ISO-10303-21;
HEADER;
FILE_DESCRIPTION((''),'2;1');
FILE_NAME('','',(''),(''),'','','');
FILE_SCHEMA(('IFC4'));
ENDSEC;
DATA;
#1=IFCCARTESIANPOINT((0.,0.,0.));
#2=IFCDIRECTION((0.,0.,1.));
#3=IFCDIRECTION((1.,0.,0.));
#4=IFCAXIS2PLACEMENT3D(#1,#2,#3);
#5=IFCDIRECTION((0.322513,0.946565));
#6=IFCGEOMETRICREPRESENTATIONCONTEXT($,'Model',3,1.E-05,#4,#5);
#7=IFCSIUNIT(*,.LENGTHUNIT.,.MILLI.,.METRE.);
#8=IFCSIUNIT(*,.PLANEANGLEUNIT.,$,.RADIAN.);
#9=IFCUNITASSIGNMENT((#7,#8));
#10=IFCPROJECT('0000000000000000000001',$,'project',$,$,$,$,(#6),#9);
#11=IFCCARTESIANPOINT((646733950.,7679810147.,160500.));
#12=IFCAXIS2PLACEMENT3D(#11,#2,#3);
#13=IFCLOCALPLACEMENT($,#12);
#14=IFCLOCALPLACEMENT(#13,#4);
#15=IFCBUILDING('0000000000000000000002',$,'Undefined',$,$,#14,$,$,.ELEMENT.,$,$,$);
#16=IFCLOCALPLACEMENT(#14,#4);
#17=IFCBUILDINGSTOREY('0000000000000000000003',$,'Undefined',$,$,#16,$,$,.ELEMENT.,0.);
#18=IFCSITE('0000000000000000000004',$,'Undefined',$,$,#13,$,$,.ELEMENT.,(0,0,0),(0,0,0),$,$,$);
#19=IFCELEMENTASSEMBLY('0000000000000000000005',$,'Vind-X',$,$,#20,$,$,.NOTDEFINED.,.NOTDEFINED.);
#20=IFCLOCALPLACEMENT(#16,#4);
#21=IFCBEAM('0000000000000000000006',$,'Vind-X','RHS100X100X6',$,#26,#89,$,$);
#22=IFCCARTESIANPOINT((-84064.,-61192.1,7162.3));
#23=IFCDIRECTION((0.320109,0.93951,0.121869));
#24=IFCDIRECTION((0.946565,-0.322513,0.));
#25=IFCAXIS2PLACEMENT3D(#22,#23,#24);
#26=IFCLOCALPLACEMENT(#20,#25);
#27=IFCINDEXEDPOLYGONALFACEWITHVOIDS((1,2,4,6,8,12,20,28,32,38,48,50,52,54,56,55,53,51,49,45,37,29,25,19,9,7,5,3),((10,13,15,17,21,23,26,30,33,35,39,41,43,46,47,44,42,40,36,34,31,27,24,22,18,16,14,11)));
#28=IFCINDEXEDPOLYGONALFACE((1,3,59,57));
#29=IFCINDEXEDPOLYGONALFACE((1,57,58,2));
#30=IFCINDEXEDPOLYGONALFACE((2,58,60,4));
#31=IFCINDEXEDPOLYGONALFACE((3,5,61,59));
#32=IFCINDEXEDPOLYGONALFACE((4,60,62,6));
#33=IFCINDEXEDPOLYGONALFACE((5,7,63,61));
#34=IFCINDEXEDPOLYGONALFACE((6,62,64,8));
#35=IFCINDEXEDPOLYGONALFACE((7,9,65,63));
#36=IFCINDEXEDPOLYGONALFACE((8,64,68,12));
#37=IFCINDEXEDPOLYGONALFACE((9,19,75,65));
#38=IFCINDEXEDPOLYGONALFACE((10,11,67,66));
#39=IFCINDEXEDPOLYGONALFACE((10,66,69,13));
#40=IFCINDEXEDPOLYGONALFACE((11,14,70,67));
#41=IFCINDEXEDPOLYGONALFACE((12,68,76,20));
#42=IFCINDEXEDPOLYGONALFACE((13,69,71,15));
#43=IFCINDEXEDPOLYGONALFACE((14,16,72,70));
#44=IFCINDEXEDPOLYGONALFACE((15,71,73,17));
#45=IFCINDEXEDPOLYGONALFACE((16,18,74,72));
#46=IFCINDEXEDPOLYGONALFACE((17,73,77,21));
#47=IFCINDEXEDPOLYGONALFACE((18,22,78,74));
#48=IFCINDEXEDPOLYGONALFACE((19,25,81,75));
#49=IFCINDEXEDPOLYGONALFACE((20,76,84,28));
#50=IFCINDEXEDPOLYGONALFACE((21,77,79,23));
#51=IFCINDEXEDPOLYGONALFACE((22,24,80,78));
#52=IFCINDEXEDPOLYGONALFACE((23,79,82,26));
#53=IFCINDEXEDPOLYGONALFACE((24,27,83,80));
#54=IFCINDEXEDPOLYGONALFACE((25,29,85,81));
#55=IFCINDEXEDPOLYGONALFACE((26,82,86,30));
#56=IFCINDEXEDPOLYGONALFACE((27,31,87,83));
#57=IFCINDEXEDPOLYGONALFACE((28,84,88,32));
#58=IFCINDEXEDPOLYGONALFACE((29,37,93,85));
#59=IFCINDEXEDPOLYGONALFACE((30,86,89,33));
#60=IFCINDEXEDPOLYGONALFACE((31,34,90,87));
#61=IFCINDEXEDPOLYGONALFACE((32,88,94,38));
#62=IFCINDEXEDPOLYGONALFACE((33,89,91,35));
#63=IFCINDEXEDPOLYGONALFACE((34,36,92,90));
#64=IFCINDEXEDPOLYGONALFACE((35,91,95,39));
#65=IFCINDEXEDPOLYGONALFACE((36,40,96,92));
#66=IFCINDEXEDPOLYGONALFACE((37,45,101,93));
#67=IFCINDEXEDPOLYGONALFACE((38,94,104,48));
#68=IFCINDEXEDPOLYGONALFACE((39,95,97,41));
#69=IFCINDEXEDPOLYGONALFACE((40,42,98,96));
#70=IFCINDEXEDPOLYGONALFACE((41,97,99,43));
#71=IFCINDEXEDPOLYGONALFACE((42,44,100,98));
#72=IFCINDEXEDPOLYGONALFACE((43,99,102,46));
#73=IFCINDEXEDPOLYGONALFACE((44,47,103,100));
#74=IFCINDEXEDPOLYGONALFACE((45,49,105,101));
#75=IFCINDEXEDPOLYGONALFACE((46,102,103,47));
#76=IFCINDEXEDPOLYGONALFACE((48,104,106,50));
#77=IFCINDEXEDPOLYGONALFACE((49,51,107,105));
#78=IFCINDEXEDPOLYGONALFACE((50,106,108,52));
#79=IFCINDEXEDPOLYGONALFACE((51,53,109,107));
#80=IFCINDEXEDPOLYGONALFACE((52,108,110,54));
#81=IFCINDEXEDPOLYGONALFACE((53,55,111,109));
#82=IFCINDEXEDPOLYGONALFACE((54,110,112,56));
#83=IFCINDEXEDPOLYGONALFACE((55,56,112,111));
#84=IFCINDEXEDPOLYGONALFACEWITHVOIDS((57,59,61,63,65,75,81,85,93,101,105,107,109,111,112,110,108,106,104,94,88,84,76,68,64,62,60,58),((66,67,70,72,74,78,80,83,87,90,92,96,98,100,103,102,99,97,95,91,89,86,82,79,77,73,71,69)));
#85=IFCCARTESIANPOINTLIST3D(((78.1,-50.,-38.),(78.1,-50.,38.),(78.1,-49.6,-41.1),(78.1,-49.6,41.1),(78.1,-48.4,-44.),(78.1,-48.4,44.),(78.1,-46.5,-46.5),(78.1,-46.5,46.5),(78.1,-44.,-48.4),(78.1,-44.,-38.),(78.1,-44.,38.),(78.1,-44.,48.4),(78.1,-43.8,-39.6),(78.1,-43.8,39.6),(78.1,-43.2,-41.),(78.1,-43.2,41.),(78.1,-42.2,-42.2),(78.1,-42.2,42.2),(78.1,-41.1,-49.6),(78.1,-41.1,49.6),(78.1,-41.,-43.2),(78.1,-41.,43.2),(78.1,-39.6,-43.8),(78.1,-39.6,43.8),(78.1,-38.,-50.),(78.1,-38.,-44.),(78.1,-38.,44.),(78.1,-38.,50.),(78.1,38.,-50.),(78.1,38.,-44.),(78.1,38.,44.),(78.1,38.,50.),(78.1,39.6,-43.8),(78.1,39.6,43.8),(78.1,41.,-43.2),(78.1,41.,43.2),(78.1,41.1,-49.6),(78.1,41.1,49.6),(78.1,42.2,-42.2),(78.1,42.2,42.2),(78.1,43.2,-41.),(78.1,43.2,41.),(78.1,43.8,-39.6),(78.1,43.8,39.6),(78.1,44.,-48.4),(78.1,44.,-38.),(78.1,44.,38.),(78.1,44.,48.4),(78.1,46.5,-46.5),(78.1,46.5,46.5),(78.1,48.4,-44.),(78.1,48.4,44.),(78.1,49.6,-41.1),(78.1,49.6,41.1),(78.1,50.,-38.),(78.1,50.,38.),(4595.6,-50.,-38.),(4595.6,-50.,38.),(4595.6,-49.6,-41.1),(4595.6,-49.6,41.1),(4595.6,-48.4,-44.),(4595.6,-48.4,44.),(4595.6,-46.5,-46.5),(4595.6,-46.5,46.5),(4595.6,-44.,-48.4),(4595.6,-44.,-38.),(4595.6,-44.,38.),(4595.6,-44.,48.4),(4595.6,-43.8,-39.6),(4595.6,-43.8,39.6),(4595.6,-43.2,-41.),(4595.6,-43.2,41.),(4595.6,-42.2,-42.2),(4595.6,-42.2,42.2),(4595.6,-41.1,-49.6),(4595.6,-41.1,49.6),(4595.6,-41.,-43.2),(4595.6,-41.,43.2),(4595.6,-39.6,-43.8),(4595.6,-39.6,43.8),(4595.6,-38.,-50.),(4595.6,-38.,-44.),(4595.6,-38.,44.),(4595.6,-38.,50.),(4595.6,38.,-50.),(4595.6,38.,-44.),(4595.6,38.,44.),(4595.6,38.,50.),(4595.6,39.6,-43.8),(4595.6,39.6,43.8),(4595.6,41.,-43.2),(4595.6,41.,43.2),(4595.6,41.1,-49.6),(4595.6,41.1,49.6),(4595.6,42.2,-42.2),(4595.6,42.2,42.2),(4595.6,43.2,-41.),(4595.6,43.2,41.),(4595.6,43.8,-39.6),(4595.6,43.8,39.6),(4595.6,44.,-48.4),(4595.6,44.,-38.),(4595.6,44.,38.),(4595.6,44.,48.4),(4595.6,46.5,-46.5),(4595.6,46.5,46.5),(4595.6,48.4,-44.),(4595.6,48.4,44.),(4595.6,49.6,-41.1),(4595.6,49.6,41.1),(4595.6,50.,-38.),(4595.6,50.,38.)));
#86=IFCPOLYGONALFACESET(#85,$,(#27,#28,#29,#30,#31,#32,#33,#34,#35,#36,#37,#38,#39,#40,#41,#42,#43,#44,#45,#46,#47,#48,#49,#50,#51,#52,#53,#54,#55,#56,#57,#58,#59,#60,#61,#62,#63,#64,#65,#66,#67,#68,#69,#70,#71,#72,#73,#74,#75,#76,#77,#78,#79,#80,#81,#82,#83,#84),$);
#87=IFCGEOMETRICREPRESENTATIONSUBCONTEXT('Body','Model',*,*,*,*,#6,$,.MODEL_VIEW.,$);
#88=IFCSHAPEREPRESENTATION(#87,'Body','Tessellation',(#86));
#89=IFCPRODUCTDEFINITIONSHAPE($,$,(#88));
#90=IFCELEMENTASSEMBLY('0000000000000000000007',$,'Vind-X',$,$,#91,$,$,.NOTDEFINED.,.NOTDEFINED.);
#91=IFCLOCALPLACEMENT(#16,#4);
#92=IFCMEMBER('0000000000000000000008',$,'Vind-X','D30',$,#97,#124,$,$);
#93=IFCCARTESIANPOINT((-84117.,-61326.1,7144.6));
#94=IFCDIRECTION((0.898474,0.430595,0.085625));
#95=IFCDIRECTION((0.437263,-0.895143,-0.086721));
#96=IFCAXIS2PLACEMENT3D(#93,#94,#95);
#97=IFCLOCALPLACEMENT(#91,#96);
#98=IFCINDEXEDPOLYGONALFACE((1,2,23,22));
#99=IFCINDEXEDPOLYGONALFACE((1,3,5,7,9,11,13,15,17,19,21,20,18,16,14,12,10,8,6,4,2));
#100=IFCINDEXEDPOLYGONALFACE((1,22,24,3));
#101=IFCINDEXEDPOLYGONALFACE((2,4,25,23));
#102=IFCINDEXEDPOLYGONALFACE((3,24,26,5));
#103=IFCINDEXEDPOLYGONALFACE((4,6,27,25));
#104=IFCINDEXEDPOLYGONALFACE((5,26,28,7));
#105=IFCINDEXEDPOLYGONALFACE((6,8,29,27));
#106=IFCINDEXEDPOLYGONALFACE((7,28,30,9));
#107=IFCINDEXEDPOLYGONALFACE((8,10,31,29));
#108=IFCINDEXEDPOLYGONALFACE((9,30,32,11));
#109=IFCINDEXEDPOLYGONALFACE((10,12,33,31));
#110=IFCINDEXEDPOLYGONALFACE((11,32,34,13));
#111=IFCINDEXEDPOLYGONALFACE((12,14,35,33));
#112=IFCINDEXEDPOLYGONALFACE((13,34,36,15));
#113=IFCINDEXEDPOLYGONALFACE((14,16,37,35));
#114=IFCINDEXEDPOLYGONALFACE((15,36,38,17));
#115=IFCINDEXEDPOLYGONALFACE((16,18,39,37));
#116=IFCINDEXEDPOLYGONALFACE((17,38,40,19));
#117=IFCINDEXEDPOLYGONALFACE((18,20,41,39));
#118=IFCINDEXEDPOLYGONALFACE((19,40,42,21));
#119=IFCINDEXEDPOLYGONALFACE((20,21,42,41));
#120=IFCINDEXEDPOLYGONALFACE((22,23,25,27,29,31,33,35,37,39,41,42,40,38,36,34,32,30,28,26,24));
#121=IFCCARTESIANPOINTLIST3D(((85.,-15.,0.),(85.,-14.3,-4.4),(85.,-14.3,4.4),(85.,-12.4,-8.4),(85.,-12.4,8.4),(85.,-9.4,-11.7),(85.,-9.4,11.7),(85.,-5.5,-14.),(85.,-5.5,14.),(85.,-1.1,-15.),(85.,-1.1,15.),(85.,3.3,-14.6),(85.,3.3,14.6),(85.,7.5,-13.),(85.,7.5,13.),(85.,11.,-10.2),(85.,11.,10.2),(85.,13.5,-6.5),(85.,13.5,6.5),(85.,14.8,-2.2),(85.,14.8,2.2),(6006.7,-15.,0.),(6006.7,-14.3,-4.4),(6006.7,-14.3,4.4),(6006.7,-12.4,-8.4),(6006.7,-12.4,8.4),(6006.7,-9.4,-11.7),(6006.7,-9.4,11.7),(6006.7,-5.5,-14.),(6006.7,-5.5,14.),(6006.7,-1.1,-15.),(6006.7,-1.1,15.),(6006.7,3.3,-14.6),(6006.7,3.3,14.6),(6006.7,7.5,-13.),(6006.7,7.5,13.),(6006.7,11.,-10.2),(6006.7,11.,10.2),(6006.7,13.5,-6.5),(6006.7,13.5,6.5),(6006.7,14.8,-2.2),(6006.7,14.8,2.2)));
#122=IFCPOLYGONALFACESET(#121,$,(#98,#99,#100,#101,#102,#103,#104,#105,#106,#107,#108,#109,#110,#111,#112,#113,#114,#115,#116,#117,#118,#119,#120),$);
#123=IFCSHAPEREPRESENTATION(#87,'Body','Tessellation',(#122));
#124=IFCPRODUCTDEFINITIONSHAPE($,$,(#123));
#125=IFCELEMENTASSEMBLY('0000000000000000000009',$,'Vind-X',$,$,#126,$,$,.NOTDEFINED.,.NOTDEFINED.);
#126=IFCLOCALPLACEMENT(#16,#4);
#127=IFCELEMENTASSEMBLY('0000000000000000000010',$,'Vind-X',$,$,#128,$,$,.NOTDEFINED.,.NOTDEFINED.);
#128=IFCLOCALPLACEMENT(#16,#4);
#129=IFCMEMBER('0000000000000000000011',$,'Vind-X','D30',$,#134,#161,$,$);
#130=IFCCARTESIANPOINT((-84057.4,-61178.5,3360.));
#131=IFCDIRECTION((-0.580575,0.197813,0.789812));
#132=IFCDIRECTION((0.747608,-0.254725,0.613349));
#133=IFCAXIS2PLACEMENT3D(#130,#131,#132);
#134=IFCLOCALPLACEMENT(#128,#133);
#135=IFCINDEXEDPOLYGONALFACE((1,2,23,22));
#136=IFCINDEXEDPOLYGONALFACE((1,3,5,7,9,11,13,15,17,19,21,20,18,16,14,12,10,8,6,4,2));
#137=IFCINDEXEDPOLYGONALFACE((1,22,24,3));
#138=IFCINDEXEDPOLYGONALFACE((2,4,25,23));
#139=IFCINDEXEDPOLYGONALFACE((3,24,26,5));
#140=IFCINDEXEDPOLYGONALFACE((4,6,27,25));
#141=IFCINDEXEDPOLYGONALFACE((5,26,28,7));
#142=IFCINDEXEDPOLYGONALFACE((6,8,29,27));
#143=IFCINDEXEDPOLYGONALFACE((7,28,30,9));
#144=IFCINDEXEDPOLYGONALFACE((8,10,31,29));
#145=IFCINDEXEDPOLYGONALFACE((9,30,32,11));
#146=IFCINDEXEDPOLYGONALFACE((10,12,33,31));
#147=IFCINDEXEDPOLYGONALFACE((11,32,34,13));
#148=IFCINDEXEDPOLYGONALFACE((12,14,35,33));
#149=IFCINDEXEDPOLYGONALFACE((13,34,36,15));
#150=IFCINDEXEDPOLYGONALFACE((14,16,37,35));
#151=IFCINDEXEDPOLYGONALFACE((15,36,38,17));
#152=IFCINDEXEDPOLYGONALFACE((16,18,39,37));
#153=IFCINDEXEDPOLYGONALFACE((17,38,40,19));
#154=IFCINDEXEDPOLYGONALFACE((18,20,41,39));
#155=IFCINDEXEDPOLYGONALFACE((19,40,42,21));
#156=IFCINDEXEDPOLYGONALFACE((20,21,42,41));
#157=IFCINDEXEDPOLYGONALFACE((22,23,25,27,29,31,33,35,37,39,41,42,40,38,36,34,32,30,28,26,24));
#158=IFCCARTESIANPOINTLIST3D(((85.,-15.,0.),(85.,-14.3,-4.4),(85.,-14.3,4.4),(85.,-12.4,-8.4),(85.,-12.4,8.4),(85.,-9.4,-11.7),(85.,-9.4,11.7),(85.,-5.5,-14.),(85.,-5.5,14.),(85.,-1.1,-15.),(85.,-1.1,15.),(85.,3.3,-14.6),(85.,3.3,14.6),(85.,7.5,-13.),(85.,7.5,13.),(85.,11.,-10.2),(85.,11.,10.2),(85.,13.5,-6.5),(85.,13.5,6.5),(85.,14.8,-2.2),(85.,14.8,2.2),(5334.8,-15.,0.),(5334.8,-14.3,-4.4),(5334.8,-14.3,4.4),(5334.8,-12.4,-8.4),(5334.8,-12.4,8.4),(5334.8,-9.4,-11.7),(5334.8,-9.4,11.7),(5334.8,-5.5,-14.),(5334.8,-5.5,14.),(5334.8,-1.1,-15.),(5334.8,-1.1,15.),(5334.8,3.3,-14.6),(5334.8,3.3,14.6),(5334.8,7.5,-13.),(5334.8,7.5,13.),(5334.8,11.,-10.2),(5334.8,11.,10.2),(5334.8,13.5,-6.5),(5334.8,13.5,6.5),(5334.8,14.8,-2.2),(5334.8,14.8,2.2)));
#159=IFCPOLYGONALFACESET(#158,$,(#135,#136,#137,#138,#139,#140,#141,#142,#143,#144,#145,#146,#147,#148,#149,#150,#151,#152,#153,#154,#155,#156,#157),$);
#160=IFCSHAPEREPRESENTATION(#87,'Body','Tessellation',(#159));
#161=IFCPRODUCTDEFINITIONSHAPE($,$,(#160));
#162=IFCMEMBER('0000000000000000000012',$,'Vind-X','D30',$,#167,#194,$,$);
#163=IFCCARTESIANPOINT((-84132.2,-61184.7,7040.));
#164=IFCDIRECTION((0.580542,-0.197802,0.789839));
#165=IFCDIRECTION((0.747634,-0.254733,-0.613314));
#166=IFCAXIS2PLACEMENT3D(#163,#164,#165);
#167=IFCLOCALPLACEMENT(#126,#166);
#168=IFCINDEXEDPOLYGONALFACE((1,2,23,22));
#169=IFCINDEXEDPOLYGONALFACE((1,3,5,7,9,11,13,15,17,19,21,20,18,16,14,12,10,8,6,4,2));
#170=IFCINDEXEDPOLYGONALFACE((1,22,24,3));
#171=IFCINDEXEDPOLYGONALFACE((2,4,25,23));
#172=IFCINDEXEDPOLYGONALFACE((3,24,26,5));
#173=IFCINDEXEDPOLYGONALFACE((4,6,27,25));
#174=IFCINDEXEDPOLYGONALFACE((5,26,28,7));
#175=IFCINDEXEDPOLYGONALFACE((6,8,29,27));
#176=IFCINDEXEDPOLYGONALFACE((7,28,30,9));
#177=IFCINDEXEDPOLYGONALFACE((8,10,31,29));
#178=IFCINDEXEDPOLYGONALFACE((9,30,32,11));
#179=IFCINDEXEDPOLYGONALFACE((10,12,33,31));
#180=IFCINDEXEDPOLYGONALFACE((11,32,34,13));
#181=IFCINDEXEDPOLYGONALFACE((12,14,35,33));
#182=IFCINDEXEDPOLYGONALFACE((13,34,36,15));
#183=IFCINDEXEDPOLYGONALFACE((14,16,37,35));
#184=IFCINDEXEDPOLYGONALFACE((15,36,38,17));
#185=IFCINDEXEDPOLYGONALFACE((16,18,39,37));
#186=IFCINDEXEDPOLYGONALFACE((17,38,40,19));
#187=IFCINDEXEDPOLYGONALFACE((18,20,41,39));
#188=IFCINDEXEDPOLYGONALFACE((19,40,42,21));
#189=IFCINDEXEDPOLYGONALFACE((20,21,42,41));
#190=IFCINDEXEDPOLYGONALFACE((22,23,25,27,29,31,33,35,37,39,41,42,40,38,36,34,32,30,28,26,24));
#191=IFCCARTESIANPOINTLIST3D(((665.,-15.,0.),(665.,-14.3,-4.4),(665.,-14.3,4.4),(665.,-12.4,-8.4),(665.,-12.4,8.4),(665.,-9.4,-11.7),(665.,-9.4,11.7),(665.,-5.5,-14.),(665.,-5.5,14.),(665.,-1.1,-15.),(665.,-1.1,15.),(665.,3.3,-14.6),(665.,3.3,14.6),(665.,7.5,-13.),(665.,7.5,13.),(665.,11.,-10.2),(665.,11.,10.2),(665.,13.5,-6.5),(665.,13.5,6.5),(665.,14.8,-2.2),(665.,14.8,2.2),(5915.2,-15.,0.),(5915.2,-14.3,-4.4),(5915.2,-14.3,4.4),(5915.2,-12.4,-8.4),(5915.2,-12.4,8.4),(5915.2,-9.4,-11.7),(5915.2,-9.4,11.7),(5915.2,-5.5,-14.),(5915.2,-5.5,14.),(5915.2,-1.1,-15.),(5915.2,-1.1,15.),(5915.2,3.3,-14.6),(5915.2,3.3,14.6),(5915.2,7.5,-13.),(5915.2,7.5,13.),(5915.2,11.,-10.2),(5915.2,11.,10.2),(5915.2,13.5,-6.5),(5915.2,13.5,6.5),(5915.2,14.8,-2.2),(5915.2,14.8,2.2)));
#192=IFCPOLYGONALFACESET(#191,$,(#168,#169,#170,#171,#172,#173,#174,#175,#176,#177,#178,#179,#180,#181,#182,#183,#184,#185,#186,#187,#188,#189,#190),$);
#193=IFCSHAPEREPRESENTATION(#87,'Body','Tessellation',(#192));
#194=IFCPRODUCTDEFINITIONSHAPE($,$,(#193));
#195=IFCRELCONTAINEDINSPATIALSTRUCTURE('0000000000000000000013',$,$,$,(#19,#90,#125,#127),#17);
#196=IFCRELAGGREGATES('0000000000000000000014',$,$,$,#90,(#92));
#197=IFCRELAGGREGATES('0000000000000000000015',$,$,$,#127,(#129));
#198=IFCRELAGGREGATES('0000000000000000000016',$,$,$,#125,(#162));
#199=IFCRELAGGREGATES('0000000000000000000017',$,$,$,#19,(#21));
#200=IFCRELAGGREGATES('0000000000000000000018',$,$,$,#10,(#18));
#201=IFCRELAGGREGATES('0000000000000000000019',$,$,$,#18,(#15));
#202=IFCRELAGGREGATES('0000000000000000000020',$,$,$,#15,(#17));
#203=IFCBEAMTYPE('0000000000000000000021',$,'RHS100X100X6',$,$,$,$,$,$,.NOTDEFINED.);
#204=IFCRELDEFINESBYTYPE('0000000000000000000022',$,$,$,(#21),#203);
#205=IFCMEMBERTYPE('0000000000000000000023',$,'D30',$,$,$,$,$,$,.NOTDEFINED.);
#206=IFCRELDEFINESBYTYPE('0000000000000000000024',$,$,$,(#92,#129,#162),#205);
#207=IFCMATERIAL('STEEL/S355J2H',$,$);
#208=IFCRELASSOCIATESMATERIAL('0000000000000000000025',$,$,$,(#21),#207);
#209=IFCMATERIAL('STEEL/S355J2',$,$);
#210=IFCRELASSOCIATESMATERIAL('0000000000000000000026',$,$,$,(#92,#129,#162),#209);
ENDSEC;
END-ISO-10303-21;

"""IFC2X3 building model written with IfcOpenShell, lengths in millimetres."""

from ifc_helpers import new_model, si_unit, direction, frame, origin_with_axes, origin_2d_with_axis, place, context, subcontext, project, spatial, hollow_rectangle, circle, extrude, clip, halfspace, material, type_object, element, aggregate, save


model = new_model("IFC2X3")

# Units and contexts
model_context = context("Model", 3, precision=1e-05, world=origin_with_axes(), true_north=direction((0.322513, 0.946565)))
body_context = subcontext(model_context, "Body", "Model", "MODEL_VIEW")
ifc_project = project(units=[si_unit("LENGTHUNIT", "METRE", prefix="MILLI"), si_unit("PLANEANGLEUNIT", "RADIAN")], contexts=[model_context])

# Site, building, storey
site_placement = place(None, frame((646733950.0, 7679810147.0, 160500.0), z_axis=(0.0, 0.0, 1.0), x_axis=(1.0, 0.0, 0.0)))
site = spatial("IfcSite", under=ifc_project, at=site_placement, Name="Undefined", CompositionType="ELEMENT", RefLatitude=(0, 0, 0), RefLongitude=(0, 0, 0))
building_placement = place(site_placement, origin_with_axes())
building = spatial("IfcBuilding", under=site, at=building_placement, Name="Undefined", CompositionType="ELEMENT")
storey_placement = place(building_placement, origin_with_axes())
storey = spatial("IfcBuildingStorey", under=building, at=storey_placement, Name="Undefined", CompositionType="ELEMENT", Elevation=0.0)

# Shared definitions
ifc_material_1 = material(Name="STEEL/S355J2H")

# Element assembly, beam
assembly_1_placement = place(storey_placement, origin_with_axes())
assembly_1 = element("IfcElementAssembly", 1, at=assembly_1_placement, inside=storey, Name="Vind-X", AssemblyPlace="NOTDEFINED", PredefinedType="NOTDEFINED")
beam_type = type_object("IfcBeamType", Name="RHS100X100X6", PredefinedType="NOTDEFINED")
beam_placement = place(assembly_1_placement, frame((-84064.0, -61192.1, 7162.3), z_axis=(0.320109, 0.93951, 0.121869), x_axis=(0.946565, -0.322513, 0.0)))
beam = element("IfcBeam", 2, at=beam_placement, type_object=beam_type, material=ifc_material_1, Name="Vind-X", Description="RHS100X100X6", context=body_context, shape_type="Clipping", body=[
    clip(clip(extrude(hollow_rectangle(XDim=100.0, YDim=100.0, WallThickness=6.0, InnerFilletRadius=6.0, OuterFilletRadius=12.0, at=origin_2d_with_axis()), frame((4674.6, 0.0, 0.0), z_axis=(-1.0, 0.0, 0.0), x_axis=(0.0, -1.0, 0.0)), (0.0, 0.0, 1.0), 4674.6), halfspace(frame((4595.6, 22.5, 0.0), z_axis=(-1.0, 0.0, 0.0), x_axis=(0.0, 0.0, 1.0)), True)), halfspace(frame((78.1, 22.5, 0.0), z_axis=(1.0, 0.0, 0.0), x_axis=(0.0, 0.0, -1.0)), True)),
])

# Element assemblies, members
assembly_2_placement = place(storey_placement, origin_with_axes())
assembly_2 = element("IfcElementAssembly", 3, at=assembly_2_placement, inside=storey, Name="Vind-X", AssemblyPlace="NOTDEFINED", PredefinedType="NOTDEFINED")
ifc_material_2 = material(Name="STEEL/S355J2")
member_type = type_object("IfcMemberType", Name="D30", PredefinedType="NOTDEFINED")
member_1_placement = place(assembly_2_placement, frame((-84117.0, -61326.1, 7144.6), z_axis=(0.898474, 0.430595, 0.085625), x_axis=(0.437263, -0.895143, -0.086721)))
member_1 = element("IfcMember", 4, at=member_1_placement, type_object=member_type, material=ifc_material_2, Name="Vind-X", Description="D30", context=body_context, shape_type="Clipping", body=[
    clip(clip(extrude(circle(Radius=15.0, at=origin_2d_with_axis()), frame((6671.7, 0.0, 0.0), z_axis=(-1.0, 0.0, 0.0), x_axis=(0.0, -1.0, 0.0)), (0.0, 0.0, 1.0), 6671.7), halfspace(frame((6006.7, -6.0, 10.2), z_axis=(1.0, 0.0, 0.0), x_axis=(0.0, 1.0, 0.0)), False)), halfspace(frame((85.0, -6.0, 16.0), z_axis=(1.0, 0.0, 0.0), x_axis=(0.0, 1.0, 0.0)), True)),
])
assembly_3_placement = place(storey_placement, origin_with_axes())
assembly_3 = element("IfcElementAssembly", 5, at=assembly_3_placement, inside=storey, Name="Vind-X", AssemblyPlace="NOTDEFINED", PredefinedType="NOTDEFINED")
assembly_4_placement = place(storey_placement, origin_with_axes())
assembly_4 = element("IfcElementAssembly", 6, at=assembly_4_placement, inside=storey, Name="Vind-X", AssemblyPlace="NOTDEFINED", PredefinedType="NOTDEFINED")
member_2_placement = place(assembly_4_placement, frame((-84057.4, -61178.5, 3360.0), z_axis=(-0.580575, 0.197813, 0.789812), x_axis=(0.747608, -0.254725, 0.613349)))
member_2 = element("IfcMember", 7, at=member_2_placement, type_object=member_type, material=ifc_material_2, Name="Vind-X", Description="D30", context=body_context, shape_type="Clipping", body=[
    clip(clip(extrude(circle(Radius=15.0, at=origin_2d_with_axis()), frame((5999.8, 0.0, 0.0), z_axis=(-1.0, 0.0, 0.0), x_axis=(0.0, -1.0, 0.0)), (0.0, 0.0, 1.0), 5999.9), halfspace(frame((5334.8, -6.0, 10.2), z_axis=(1.0, 0.0, 0.0), x_axis=(0.0, 1.0, 0.0)), False)), halfspace(frame((85.0, -6.0, 16.0), z_axis=(1.0, 0.0, 0.0), x_axis=(0.0, 1.0, 0.0)), True)),
])

# Member
member_3_placement = place(assembly_3_placement, frame((-84132.2, -61184.7, 7040.0), z_axis=(0.580542, -0.197802, 0.789839), x_axis=(0.747634, -0.254733, -0.613314)))
member_3 = element("IfcMember", 8, at=member_3_placement, type_object=member_type, material=ifc_material_2, Name="Vind-X", Description="D30", context=body_context, shape_type="Clipping", body=[
    clip(clip(extrude(circle(Radius=15.0, at=origin_2d_with_axis()), frame((6000.2, 0.0, 0.0), z_axis=(-1.0, 0.0, 0.0), x_axis=(0.0, -1.0, 0.0)), (0.0, 0.0, 1.0), 6000.2), halfspace(frame((5915.2, 6.0, 16.0), z_axis=(-1.0, 0.0, 0.0), x_axis=(0.0, -1.0, 0.0)), True)), halfspace(frame((665.0, 6.0, 10.2), z_axis=(-1.0, 0.0, 0.0), x_axis=(0.0, -1.0, 0.0)), False)),
])

aggregate(assembly_2, [member_1])
aggregate(assembly_4, [member_2])
aggregate(assembly_3, [member_3])
aggregate(assembly_1, [beam])

save(model, "model.ifc")
